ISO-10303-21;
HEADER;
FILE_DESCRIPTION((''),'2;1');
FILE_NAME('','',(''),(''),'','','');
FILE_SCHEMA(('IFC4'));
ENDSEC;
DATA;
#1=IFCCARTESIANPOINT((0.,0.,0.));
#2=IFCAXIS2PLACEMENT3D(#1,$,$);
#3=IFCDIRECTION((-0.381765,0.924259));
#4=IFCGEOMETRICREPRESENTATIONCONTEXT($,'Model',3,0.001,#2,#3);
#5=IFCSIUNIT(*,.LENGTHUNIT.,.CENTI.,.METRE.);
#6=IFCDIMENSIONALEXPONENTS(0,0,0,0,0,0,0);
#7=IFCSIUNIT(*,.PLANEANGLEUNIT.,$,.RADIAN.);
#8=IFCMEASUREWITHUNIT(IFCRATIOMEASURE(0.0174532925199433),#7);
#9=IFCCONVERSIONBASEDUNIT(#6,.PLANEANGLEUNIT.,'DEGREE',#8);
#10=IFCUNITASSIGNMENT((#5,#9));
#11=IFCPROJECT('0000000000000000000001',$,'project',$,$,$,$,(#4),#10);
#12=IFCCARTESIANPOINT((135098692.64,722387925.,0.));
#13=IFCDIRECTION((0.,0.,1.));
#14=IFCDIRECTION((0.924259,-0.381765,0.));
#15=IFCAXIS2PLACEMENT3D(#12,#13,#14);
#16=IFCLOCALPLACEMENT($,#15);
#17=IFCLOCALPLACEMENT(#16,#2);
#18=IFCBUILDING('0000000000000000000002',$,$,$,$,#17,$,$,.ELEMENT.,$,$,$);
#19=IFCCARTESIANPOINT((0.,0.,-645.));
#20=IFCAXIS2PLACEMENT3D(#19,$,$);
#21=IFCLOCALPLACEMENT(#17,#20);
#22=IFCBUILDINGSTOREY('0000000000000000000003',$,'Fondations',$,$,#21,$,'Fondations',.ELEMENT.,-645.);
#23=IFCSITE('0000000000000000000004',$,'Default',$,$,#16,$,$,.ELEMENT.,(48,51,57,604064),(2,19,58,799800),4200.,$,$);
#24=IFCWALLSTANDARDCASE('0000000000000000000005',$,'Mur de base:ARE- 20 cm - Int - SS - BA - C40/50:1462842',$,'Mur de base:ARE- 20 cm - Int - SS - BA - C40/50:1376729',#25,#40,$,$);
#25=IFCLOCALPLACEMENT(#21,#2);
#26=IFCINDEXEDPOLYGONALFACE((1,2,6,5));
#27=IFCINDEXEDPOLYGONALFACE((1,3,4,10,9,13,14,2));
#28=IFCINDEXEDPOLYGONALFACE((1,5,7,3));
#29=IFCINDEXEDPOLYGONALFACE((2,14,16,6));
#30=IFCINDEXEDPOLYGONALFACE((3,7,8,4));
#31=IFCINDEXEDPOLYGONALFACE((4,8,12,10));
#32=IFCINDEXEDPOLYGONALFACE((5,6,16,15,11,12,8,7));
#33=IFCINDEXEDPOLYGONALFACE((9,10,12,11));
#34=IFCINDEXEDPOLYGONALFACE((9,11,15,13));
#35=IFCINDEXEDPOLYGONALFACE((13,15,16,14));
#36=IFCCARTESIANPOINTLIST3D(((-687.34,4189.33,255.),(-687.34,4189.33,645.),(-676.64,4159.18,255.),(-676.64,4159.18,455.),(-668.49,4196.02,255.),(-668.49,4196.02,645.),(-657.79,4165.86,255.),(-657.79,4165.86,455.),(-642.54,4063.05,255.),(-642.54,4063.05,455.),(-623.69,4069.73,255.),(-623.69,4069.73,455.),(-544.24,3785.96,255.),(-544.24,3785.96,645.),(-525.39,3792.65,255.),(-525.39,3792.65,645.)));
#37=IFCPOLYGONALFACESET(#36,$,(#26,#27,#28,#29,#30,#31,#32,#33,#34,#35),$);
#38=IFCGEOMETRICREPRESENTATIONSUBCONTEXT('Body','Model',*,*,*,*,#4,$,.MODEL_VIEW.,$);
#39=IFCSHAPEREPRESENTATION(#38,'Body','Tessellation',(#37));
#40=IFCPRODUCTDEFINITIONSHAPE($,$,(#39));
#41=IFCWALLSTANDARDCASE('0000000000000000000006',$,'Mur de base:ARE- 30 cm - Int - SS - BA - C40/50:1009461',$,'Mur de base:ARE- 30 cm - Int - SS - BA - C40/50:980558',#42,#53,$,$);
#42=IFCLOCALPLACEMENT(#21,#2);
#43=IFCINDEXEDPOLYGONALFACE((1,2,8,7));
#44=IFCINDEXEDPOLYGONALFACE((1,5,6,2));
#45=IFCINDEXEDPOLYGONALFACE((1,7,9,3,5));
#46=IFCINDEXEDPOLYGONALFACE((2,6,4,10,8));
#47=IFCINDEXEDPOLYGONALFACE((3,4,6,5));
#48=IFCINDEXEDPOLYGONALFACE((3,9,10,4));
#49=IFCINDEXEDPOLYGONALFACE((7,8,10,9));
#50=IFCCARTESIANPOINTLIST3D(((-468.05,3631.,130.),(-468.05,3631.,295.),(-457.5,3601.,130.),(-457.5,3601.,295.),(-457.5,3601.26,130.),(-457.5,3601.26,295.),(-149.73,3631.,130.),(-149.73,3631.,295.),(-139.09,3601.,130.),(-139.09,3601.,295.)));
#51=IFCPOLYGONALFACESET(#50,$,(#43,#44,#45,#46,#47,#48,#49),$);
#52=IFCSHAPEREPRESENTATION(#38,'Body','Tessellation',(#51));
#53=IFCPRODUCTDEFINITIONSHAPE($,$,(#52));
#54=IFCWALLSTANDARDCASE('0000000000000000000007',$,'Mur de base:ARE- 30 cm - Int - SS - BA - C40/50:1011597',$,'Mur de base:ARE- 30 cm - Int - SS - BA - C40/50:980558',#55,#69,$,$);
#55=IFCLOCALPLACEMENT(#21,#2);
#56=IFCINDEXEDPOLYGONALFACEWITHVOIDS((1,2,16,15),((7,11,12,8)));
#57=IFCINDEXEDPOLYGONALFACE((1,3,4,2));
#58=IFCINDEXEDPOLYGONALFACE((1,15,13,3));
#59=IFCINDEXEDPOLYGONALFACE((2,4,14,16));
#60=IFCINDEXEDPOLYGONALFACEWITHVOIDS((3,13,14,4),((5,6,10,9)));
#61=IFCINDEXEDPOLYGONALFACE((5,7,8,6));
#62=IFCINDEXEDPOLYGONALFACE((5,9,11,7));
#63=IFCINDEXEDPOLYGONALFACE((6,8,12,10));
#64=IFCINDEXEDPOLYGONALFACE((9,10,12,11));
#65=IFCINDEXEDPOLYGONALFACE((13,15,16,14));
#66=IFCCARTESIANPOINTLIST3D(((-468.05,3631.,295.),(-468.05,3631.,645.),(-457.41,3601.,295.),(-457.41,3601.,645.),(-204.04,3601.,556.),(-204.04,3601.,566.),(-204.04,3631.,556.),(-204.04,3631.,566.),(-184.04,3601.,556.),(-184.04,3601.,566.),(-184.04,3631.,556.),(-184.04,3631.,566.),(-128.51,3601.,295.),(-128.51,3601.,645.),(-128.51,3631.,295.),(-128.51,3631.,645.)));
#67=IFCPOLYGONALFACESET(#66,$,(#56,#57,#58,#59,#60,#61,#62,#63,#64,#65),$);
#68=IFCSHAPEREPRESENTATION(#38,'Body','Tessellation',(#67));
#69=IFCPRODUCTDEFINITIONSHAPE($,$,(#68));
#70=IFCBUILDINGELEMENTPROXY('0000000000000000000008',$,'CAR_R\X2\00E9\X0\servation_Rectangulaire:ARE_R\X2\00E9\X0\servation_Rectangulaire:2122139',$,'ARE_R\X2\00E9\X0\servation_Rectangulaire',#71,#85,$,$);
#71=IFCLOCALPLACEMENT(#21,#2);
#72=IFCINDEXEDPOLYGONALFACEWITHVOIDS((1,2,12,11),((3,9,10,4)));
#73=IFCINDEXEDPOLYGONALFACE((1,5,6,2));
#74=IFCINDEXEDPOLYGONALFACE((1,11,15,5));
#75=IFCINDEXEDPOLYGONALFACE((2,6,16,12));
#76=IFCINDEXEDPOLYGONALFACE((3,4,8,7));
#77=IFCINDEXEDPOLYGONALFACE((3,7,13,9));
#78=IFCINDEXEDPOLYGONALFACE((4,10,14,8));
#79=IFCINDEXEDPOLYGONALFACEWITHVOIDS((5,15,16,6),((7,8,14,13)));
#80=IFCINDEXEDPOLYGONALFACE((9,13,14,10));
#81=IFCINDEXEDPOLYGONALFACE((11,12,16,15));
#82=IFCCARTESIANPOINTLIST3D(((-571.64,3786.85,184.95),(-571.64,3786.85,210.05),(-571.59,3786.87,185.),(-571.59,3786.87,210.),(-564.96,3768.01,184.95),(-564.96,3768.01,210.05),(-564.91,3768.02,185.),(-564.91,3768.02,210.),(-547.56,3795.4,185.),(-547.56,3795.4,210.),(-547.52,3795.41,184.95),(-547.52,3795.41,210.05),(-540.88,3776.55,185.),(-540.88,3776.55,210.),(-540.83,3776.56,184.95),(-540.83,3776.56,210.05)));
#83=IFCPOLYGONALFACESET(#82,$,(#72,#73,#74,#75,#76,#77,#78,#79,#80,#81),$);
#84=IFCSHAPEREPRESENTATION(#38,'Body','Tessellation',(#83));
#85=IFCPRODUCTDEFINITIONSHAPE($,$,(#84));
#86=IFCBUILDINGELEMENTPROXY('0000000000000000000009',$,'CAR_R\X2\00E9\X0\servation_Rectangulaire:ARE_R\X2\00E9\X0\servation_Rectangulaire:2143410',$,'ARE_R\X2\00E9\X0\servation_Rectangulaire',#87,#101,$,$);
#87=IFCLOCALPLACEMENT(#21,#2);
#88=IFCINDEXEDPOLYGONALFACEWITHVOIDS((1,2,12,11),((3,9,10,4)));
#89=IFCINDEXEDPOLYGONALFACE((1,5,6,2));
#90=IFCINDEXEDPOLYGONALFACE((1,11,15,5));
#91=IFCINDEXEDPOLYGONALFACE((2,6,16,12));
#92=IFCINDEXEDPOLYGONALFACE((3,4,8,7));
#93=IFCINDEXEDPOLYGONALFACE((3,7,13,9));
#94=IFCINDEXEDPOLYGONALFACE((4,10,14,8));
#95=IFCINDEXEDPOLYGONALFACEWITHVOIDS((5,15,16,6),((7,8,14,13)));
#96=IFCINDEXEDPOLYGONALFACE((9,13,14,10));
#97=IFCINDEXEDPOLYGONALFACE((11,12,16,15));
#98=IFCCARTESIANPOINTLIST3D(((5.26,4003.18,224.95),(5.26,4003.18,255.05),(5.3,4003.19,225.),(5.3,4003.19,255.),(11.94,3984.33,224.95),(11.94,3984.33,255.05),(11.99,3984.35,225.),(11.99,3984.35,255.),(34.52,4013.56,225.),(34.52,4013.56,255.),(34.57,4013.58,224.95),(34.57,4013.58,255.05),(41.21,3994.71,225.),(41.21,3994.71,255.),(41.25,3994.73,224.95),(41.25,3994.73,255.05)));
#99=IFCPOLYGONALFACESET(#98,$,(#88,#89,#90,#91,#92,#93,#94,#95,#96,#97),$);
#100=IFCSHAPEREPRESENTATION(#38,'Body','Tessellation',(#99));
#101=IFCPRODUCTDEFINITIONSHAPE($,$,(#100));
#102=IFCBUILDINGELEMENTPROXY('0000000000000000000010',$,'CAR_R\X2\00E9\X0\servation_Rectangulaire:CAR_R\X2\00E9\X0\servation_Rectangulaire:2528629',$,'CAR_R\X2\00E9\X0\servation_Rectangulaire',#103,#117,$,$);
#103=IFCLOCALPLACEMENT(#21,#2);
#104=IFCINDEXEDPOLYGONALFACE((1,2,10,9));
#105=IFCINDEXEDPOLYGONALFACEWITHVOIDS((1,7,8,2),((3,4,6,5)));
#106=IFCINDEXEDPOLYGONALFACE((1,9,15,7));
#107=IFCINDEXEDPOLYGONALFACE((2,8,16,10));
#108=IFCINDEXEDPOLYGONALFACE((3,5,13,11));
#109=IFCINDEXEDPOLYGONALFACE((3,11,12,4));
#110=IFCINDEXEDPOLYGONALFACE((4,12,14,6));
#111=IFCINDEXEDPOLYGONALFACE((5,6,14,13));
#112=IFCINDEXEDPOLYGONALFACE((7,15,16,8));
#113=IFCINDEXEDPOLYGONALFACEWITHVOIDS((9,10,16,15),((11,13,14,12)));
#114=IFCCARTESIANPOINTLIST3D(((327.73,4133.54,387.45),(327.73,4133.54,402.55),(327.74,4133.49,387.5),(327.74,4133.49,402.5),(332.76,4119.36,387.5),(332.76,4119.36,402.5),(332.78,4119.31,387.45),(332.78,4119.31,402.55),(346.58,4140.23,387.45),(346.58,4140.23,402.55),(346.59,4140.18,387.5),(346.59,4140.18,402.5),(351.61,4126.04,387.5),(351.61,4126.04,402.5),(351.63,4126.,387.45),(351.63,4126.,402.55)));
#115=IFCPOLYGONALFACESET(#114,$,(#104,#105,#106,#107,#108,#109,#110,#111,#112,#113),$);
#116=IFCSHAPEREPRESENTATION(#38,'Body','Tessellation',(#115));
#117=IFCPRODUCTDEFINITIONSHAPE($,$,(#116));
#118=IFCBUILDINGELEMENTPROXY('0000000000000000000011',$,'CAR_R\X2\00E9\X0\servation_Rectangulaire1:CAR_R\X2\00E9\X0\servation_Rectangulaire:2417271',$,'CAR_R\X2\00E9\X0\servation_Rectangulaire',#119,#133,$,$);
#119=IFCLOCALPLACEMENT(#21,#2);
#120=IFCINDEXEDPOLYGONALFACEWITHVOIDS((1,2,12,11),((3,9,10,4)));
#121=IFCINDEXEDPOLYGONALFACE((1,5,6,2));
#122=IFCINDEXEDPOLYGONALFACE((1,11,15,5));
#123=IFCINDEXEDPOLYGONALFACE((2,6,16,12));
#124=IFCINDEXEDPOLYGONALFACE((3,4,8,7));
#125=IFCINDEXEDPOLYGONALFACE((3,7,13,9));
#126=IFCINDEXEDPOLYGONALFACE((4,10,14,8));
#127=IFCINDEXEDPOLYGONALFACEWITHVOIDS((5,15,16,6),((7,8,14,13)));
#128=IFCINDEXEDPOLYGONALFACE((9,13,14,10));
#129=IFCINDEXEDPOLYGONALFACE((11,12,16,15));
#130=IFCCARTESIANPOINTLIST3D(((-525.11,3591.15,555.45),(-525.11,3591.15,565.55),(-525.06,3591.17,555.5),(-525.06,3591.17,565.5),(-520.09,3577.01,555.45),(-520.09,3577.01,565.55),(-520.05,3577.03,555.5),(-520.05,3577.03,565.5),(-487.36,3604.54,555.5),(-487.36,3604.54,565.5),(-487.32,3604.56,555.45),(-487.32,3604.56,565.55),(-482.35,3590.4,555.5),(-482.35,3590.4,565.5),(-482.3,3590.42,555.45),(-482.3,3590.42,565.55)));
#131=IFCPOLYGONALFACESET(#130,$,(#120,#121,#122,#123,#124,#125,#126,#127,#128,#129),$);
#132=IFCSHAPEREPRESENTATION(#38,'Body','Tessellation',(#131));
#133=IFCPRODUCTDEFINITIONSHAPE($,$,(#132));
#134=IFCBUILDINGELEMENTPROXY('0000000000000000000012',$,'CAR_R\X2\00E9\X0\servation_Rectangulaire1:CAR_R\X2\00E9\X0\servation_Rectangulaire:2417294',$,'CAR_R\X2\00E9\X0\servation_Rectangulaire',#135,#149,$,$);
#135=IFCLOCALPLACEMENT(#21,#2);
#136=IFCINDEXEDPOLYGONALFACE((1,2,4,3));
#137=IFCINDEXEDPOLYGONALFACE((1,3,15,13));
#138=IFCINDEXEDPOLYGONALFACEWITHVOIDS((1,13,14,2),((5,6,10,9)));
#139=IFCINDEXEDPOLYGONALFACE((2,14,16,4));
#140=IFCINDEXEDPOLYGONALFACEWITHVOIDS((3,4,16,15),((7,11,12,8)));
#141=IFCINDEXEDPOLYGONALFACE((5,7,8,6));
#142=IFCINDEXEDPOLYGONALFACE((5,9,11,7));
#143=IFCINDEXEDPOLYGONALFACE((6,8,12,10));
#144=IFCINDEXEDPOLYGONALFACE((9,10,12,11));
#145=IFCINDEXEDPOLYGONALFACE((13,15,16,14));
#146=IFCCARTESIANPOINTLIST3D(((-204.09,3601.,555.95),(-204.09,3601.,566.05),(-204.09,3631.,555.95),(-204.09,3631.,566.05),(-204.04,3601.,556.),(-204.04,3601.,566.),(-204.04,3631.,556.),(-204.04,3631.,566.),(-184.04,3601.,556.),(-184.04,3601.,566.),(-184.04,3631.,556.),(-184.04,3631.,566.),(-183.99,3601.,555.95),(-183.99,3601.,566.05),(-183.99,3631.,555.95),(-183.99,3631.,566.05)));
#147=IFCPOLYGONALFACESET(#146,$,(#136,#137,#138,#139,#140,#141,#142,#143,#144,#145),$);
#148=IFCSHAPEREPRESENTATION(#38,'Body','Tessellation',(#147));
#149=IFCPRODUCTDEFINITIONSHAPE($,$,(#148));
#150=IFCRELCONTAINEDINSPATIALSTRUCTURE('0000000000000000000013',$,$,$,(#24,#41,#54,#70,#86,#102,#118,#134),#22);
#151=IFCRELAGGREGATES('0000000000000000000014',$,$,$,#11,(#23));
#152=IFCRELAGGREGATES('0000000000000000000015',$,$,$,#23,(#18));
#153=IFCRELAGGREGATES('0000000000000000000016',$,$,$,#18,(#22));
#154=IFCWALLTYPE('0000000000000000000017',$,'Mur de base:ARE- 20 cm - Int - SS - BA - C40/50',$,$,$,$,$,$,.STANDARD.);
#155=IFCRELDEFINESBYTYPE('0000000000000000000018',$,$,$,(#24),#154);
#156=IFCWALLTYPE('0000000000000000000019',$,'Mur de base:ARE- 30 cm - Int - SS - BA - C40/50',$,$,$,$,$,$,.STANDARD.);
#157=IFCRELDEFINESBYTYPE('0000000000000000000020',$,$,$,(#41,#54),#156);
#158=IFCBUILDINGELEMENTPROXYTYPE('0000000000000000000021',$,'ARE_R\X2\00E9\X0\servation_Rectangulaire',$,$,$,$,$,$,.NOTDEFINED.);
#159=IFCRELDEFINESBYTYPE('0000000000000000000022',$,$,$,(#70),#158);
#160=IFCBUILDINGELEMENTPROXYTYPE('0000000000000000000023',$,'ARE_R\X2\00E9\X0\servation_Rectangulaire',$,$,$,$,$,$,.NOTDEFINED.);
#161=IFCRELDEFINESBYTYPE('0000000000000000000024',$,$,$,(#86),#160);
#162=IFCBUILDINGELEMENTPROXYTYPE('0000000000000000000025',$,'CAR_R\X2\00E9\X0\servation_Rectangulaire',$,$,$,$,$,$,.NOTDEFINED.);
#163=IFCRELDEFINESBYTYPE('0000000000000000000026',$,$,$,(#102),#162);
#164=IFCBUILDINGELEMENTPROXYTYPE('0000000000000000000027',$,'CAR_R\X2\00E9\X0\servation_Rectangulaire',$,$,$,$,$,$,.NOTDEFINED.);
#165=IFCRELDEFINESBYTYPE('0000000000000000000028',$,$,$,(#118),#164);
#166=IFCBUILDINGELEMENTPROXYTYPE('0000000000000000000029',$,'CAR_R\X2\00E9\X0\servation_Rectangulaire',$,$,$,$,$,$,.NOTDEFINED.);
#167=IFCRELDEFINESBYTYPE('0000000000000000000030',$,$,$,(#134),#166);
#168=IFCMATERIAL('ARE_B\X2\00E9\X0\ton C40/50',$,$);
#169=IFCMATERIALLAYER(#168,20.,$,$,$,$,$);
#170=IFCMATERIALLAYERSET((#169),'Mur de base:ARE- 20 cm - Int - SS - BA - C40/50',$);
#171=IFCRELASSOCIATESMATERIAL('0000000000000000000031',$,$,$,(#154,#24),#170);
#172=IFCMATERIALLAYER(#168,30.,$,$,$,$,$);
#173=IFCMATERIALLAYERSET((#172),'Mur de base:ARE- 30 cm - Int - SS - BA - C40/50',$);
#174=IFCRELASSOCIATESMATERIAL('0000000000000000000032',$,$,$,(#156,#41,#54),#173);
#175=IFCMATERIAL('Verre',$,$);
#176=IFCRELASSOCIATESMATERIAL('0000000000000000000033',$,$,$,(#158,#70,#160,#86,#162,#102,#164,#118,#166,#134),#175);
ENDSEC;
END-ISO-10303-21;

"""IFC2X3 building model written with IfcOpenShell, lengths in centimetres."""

from ifc_helpers import new_model, entity, si_unit, converted_unit, direction, frame, frame_2d, origin, place, context, subcontext, project, spatial, polyline, rectangle, outline, extrude, source, transform, mapped, material, layer, layer_set, layer_usage, type_object, type_shapes, element, save


model = new_model("IFC2X3")

# Units and contexts
model_context = context("Model", 3, precision=0.001, world=origin(), true_north=direction((-0.381765, 0.924259)))
body_context = subcontext(model_context, "Body", "Model", "MODEL_VIEW")
ifc_project = project(units=[si_unit("LENGTHUNIT", "METRE", prefix="CENTI"), converted_unit("PLANEANGLEUNIT", "DEGREE", entity("IfcRatioMeasure", 0.0174532925199433), si_unit("PLANEANGLEUNIT", "RADIAN"), dimensions=[0, 0, 0, 0, 0, 0, 0])], contexts=[model_context])

# Site, building, storey
site_placement = place(None, frame((135098692.64, 722387925.0, 0.0), z_axis=(0.0, 0.0, 1.0), x_axis=(0.924259, -0.381765, 0.0)))
site = spatial("IfcSite", under=ifc_project, at=site_placement, Name="Default", CompositionType="ELEMENT", RefLatitude=(48, 51, 57, 604064), RefLongitude=(2, 19, 58, 799800), RefElevation=4200.0)
building_placement = place(site_placement, origin())
building = spatial("IfcBuilding", under=site, at=building_placement, CompositionType="ELEMENT")
storey_placement = place(building_placement, frame((0.0, 0.0, -645.0)))
storey = spatial("IfcBuildingStorey", under=building, at=storey_placement, Name="Fondations", LongName="Fondations", CompositionType="ELEMENT", Elevation=-645.0)

# Shared definitions
ifc_material_1 = material(Name="ARE_Béton C40/50")

# Shared definitions
ifc_layer_1 = layer(ifc_material_1, 20.0)
ifc_layer_set_1 = layer_set([ifc_layer_1], Name="Mur de base:ARE- 20 cm - Int - SS - BA - C40/50")
wall_type_1 = type_object("IfcWallType", Name="Mur de base:ARE- 20 cm - Int - SS - BA - C40/50", PredefinedType="STANDARD", material=ifc_layer_set_1)

# Wall, opening
ifc_layer_usage_1 = layer_usage(ifc_layer_set_1, "AXIS2", "NEGATIVE", 10.0)
wall_1_placement = place(storey_placement, frame((-534.82, 3789.31, 255.0), z_axis=(0.0, 0.0, 1.0), x_axis=(-0.334331, 0.942456, 0.0)))
wall_1 = element("IfcWallStandardCase", 1, at=wall_1_placement, inside=storey, type_object=wall_type_1, material=ifc_layer_usage_1, Name="Mur de base:ARE- 20 cm - Int - SS - BA - C40/50:1462842", ObjectType="Mur de base:ARE- 20 cm - Int - SS - BA - C40/50:1376729", context=body_context, shape_type="SweptSolid", body=[
    extrude(rectangle(XDim=428.0, YDim=20.0, at=frame_2d((214.0, 0.0), x_axis=(-1.0, 0.0))), origin(), (0.0, 0.0, 1.0), 390.0),
])
opening_1_placement = place(wall_1_placement, frame((-3750.06, 762.84, -255.0), z_axis=(0.0, 0.0, 1.0), x_axis=(-0.334331, -0.942456, 0.0)))
element("IfcOpeningElement", 2, at=opening_1_placement, cuts=wall_1, ObjectType="Opening", context=body_context, shape_type="SweptSolid", body=[
    extrude(rectangle(XDim=200.0, YDim=102.0, at=frame_2d((0.0, 0.0), x_axis=(1.0, 0.0))), frame((-515.96, 4162.06, 355.0), z_axis=(-0.942456, -0.334331, 0.0), x_axis=(0.0, 0.0, -1.0)), (0.0, 0.0, 1.0), 304.8),
])

# Wall
ifc_layer_2 = layer(ifc_material_1, 30.0)
ifc_layer_set_2 = layer_set([ifc_layer_2], Name="Mur de base:ARE- 30 cm - Int - SS - BA - C40/50")
ifc_layer_usage_2 = layer_usage(ifc_layer_set_2, "AXIS2", "NEGATIVE", 15.0)
wall_type_2 = type_object("IfcWallType", Name="Mur de base:ARE- 30 cm - Int - SS - BA - C40/50", PredefinedType="STANDARD", material=ifc_layer_set_2)
wall_2_placement = place(storey_placement, frame((-468.05, 3616.0, 130.0)))
element("IfcWallStandardCase", 3, at=wall_2_placement, inside=storey, type_object=wall_type_2, material=ifc_layer_usage_2, Name="Mur de base:ARE- 30 cm - Int - SS - BA - C40/50:1009461", ObjectType="Mur de base:ARE- 30 cm - Int - SS - BA - C40/50:980558", context=body_context, shape_type="SweptSolid", body=[
    extrude(outline(polyline([(328.96, -15.0), (318.32, 15.0), (0.0, 15.0), (10.55, -14.74), (10.55, -15.0), (328.96, -15.0)])), origin(), (0.0, 0.0, 1.0), 165.0),
])

# Wall, opening
ifc_layer_usage_3 = layer_usage(ifc_layer_set_2, "AXIS2", "NEGATIVE", 15.0)
wall_3_placement = place(storey_placement, frame((-468.05, 3616.0, 295.0)))
wall_3 = element("IfcWallStandardCase", 4, at=wall_3_placement, inside=storey, type_object=wall_type_2, material=ifc_layer_usage_3, Name="Mur de base:ARE- 30 cm - Int - SS - BA - C40/50:1011597", ObjectType="Mur de base:ARE- 30 cm - Int - SS - BA - C40/50:980558", context=body_context, shape_type="SweptSolid", body=[
    extrude(outline(polyline([(339.54, -15.0), (339.54, 15.0), (318.32, 15.0), (0.0, 15.0), (10.64, -15.0), (15.57, -15.0), (339.54, -15.0)])), origin(), (0.0, 0.0, 1.0), 350.0),
])
opening_2_placement = place(wall_3_placement, origin())
element("IfcOpeningElement", 5, at=opening_2_placement, cuts=wall_3, ObjectType="Opening", context=body_context, shape_type="SweptSolid", body=[
    extrude(rectangle(XDim=10.0, YDim=20.0, at=frame_2d((0.0, 0.0), x_axis=(0.0, 1.0))), frame((274.01, -15.0, 266.0), z_axis=(0.0, 1.0, 0.0), x_axis=(1.0, 0.0, 0.0)), (0.0, 0.0, 1.0), 30.0),
])

# Building element proxies
ifc_material_2 = material(Name="Verre")
building_element_proxy_type_1 = type_object("IfcBuildingElementProxyType", Name="ARE_Réservation_Rectangulaire", PredefinedType="NOTDEFINED", material=ifc_material_2)
shared_shape_1 = source(origin(), body_context, "Body", "SweptSolid", [
    extrude(outline(polyline([(-12.8, -12.55), (12.8, -12.55), (12.8, 12.55), (-12.8, 12.55), (-12.8, -12.55)]), holes=[polyline([(12.75, -12.5), (-12.75, -12.5), (-12.75, 12.5), (12.75, 12.5), (12.75, -12.5)])]), frame((0.0, 0.0, -20.0), z_axis=(0.0, 0.0, 1.0), x_axis=(-1.0, 0.0, 0.0)), (0.0, 0.0, 1.0), 20.0),
])
type_shapes(building_element_proxy_type_1, [shared_shape_1])
proxy_1_placement = place(storey_placement, frame((-552.89, 3772.28, 197.5), z_axis=(0.334331, -0.942456, 0.0), x_axis=(0.942456, 0.334331, 0.0)))
element("IfcBuildingElementProxy", 6, at=proxy_1_placement, inside=storey, type_object=building_element_proxy_type_1, material=ifc_material_2, Name="CAR_Réservation_Rectangulaire:ARE_Réservation_Rectangulaire:2122139", ObjectType="ARE_Réservation_Rectangulaire", context=body_context, shape_type="MappedRepresentation", body=[
    mapped(shared_shape_1, transform((0.0, 0.0, 0.0), scale=1.0)),
])
building_element_proxy_type_2 = type_object("IfcBuildingElementProxyType", Name="ARE_Réservation_Rectangulaire", PredefinedType="NOTDEFINED", material=ifc_material_2)
shared_shape_2 = source(origin(), body_context, "Body", "SweptSolid", [
    extrude(outline(polyline([(-15.55, -15.05), (15.55, -15.05), (15.55, 15.05), (-15.55, 15.05), (-15.55, -15.05)]), holes=[polyline([(15.5, -15.0), (-15.5, -15.0), (-15.5, 15.0), (15.5, 15.0), (15.5, -15.0)])]), frame((0.0, 0.0, -20.0), z_axis=(0.0, 0.0, 1.0), x_axis=(-1.0, 0.0, 0.0)), (0.0, 0.0, 1.0), 20.0),
])
type_shapes(building_element_proxy_type_2, [shared_shape_2])
proxy_2_placement = place(storey_placement, frame((26.6, 3989.53, 240.0), z_axis=(0.334331, -0.942456, 0.0), x_axis=(0.942456, 0.334331, 0.0)))
element("IfcBuildingElementProxy", 7, at=proxy_2_placement, inside=storey, type_object=building_element_proxy_type_2, material=ifc_material_2, Name="CAR_Réservation_Rectangulaire:ARE_Réservation_Rectangulaire:2143410", ObjectType="ARE_Réservation_Rectangulaire", context=body_context, shape_type="MappedRepresentation", body=[
    mapped(shared_shape_2, transform((0.0, 0.0, 0.0), scale=1.0)),
])
building_element_proxy_type_3 = type_object("IfcBuildingElementProxyType", Name="CAR_Réservation_Rectangulaire", PredefinedType="NOTDEFINED", material=ifc_material_2)
shared_shape_3 = source(origin(), body_context, "Body", "SweptSolid", [
    extrude(outline(polyline([(-7.55, -7.55), (7.55, -7.55), (7.55, 7.55), (-7.55, 7.55), (-7.55, -7.55)]), holes=[polyline([(7.5, -7.5), (-7.5, -7.5), (-7.5, 7.5), (7.5, 7.5), (7.5, -7.5)])]), frame((0.0, 0.0, -10.0), z_axis=(0.0, 0.0, 1.0), x_axis=(-1.0, 0.0, 0.0)), (0.0, 0.0, 1.0), 20.0),
])
type_shapes(building_element_proxy_type_3, [shared_shape_3])
proxy_3_placement = place(storey_placement, frame((339.68, 4129.77, 395.0), z_axis=(0.942456, 0.334331, 0.0), x_axis=(-0.334331, 0.942456, 0.0)))
element("IfcBuildingElementProxy", 8, at=proxy_3_placement, inside=storey, type_object=building_element_proxy_type_3, material=ifc_material_2, Name="CAR_Réservation_Rectangulaire:CAR_Réservation_Rectangulaire:2528629", ObjectType="CAR_Réservation_Rectangulaire", context=body_context, shape_type="MappedRepresentation", body=[
    mapped(shared_shape_3, transform((0.0, 0.0, 0.0), scale=1.0)),
])
building_element_proxy_type_4 = type_object("IfcBuildingElementProxyType", Name="CAR_Réservation_Rectangulaire", PredefinedType="NOTDEFINED", material=ifc_material_2)
shared_shape_4 = source(origin(), body_context, "Body", "SweptSolid", [
    extrude(outline(polyline([(-20.05, -5.05), (20.05, -5.05), (20.05, 5.05), (-20.05, 5.05), (-20.05, -5.05)]), holes=[polyline([(20.0, -5.0), (-20.0, -5.0), (-20.0, 5.0), (20.0, 5.0), (20.0, -5.0)])]), frame((0.0, 0.0, -15.0), z_axis=(0.0, 0.0, 1.0), x_axis=(-1.0, 0.0, 0.0)), (0.0, 0.0, 1.0), 15.0),
])
type_shapes(building_element_proxy_type_4, [shared_shape_4])
proxy_4_placement = place(storey_placement, frame((-501.2, 3583.72, 560.5), z_axis=(0.334331, -0.942456, 0.0), x_axis=(0.942456, 0.334331, 0.0)))
element("IfcBuildingElementProxy", 9, at=proxy_4_placement, inside=storey, type_object=building_element_proxy_type_4, material=ifc_material_2, Name="CAR_Réservation_Rectangulaire1:CAR_Réservation_Rectangulaire:2417271", ObjectType="CAR_Réservation_Rectangulaire", context=body_context, shape_type="MappedRepresentation", body=[
    mapped(shared_shape_4, transform((0.0, 0.0, 0.0), scale=1.0)),
])
building_element_proxy_type_5 = type_object("IfcBuildingElementProxyType", Name="CAR_Réservation_Rectangulaire", PredefinedType="NOTDEFINED", material=ifc_material_2)
shared_shape_5 = source(origin(), body_context, "Body", "SweptSolid", [
    extrude(outline(polyline([(-10.05, -5.05), (10.05, -5.05), (10.05, 5.05), (-10.05, 5.05), (-10.05, -5.05)]), holes=[polyline([(10.0, -5.0), (-10.0, -5.0), (-10.0, 5.0), (10.0, 5.0), (10.0, -5.0)])]), frame((0.0, 0.0, -30.0), z_axis=(0.0, 0.0, 1.0), x_axis=(-1.0, 0.0, 0.0)), (0.0, 0.0, 1.0), 30.0),
])
type_shapes(building_element_proxy_type_5, [shared_shape_5])
proxy_5_placement = place(storey_placement, frame((-194.04, 3631.0, 561.0), z_axis=(0.0, 1.0, 0.0), x_axis=(-1.0, 0.0, 0.0)))
element("IfcBuildingElementProxy", 10, at=proxy_5_placement, inside=storey, type_object=building_element_proxy_type_5, material=ifc_material_2, Name="CAR_Réservation_Rectangulaire1:CAR_Réservation_Rectangulaire:2417294", ObjectType="CAR_Réservation_Rectangulaire", context=body_context, shape_type="MappedRepresentation", body=[
    mapped(shared_shape_5, transform((0.0, 0.0, 0.0), scale=1.0)),
])

save(model, "model.ifc")
